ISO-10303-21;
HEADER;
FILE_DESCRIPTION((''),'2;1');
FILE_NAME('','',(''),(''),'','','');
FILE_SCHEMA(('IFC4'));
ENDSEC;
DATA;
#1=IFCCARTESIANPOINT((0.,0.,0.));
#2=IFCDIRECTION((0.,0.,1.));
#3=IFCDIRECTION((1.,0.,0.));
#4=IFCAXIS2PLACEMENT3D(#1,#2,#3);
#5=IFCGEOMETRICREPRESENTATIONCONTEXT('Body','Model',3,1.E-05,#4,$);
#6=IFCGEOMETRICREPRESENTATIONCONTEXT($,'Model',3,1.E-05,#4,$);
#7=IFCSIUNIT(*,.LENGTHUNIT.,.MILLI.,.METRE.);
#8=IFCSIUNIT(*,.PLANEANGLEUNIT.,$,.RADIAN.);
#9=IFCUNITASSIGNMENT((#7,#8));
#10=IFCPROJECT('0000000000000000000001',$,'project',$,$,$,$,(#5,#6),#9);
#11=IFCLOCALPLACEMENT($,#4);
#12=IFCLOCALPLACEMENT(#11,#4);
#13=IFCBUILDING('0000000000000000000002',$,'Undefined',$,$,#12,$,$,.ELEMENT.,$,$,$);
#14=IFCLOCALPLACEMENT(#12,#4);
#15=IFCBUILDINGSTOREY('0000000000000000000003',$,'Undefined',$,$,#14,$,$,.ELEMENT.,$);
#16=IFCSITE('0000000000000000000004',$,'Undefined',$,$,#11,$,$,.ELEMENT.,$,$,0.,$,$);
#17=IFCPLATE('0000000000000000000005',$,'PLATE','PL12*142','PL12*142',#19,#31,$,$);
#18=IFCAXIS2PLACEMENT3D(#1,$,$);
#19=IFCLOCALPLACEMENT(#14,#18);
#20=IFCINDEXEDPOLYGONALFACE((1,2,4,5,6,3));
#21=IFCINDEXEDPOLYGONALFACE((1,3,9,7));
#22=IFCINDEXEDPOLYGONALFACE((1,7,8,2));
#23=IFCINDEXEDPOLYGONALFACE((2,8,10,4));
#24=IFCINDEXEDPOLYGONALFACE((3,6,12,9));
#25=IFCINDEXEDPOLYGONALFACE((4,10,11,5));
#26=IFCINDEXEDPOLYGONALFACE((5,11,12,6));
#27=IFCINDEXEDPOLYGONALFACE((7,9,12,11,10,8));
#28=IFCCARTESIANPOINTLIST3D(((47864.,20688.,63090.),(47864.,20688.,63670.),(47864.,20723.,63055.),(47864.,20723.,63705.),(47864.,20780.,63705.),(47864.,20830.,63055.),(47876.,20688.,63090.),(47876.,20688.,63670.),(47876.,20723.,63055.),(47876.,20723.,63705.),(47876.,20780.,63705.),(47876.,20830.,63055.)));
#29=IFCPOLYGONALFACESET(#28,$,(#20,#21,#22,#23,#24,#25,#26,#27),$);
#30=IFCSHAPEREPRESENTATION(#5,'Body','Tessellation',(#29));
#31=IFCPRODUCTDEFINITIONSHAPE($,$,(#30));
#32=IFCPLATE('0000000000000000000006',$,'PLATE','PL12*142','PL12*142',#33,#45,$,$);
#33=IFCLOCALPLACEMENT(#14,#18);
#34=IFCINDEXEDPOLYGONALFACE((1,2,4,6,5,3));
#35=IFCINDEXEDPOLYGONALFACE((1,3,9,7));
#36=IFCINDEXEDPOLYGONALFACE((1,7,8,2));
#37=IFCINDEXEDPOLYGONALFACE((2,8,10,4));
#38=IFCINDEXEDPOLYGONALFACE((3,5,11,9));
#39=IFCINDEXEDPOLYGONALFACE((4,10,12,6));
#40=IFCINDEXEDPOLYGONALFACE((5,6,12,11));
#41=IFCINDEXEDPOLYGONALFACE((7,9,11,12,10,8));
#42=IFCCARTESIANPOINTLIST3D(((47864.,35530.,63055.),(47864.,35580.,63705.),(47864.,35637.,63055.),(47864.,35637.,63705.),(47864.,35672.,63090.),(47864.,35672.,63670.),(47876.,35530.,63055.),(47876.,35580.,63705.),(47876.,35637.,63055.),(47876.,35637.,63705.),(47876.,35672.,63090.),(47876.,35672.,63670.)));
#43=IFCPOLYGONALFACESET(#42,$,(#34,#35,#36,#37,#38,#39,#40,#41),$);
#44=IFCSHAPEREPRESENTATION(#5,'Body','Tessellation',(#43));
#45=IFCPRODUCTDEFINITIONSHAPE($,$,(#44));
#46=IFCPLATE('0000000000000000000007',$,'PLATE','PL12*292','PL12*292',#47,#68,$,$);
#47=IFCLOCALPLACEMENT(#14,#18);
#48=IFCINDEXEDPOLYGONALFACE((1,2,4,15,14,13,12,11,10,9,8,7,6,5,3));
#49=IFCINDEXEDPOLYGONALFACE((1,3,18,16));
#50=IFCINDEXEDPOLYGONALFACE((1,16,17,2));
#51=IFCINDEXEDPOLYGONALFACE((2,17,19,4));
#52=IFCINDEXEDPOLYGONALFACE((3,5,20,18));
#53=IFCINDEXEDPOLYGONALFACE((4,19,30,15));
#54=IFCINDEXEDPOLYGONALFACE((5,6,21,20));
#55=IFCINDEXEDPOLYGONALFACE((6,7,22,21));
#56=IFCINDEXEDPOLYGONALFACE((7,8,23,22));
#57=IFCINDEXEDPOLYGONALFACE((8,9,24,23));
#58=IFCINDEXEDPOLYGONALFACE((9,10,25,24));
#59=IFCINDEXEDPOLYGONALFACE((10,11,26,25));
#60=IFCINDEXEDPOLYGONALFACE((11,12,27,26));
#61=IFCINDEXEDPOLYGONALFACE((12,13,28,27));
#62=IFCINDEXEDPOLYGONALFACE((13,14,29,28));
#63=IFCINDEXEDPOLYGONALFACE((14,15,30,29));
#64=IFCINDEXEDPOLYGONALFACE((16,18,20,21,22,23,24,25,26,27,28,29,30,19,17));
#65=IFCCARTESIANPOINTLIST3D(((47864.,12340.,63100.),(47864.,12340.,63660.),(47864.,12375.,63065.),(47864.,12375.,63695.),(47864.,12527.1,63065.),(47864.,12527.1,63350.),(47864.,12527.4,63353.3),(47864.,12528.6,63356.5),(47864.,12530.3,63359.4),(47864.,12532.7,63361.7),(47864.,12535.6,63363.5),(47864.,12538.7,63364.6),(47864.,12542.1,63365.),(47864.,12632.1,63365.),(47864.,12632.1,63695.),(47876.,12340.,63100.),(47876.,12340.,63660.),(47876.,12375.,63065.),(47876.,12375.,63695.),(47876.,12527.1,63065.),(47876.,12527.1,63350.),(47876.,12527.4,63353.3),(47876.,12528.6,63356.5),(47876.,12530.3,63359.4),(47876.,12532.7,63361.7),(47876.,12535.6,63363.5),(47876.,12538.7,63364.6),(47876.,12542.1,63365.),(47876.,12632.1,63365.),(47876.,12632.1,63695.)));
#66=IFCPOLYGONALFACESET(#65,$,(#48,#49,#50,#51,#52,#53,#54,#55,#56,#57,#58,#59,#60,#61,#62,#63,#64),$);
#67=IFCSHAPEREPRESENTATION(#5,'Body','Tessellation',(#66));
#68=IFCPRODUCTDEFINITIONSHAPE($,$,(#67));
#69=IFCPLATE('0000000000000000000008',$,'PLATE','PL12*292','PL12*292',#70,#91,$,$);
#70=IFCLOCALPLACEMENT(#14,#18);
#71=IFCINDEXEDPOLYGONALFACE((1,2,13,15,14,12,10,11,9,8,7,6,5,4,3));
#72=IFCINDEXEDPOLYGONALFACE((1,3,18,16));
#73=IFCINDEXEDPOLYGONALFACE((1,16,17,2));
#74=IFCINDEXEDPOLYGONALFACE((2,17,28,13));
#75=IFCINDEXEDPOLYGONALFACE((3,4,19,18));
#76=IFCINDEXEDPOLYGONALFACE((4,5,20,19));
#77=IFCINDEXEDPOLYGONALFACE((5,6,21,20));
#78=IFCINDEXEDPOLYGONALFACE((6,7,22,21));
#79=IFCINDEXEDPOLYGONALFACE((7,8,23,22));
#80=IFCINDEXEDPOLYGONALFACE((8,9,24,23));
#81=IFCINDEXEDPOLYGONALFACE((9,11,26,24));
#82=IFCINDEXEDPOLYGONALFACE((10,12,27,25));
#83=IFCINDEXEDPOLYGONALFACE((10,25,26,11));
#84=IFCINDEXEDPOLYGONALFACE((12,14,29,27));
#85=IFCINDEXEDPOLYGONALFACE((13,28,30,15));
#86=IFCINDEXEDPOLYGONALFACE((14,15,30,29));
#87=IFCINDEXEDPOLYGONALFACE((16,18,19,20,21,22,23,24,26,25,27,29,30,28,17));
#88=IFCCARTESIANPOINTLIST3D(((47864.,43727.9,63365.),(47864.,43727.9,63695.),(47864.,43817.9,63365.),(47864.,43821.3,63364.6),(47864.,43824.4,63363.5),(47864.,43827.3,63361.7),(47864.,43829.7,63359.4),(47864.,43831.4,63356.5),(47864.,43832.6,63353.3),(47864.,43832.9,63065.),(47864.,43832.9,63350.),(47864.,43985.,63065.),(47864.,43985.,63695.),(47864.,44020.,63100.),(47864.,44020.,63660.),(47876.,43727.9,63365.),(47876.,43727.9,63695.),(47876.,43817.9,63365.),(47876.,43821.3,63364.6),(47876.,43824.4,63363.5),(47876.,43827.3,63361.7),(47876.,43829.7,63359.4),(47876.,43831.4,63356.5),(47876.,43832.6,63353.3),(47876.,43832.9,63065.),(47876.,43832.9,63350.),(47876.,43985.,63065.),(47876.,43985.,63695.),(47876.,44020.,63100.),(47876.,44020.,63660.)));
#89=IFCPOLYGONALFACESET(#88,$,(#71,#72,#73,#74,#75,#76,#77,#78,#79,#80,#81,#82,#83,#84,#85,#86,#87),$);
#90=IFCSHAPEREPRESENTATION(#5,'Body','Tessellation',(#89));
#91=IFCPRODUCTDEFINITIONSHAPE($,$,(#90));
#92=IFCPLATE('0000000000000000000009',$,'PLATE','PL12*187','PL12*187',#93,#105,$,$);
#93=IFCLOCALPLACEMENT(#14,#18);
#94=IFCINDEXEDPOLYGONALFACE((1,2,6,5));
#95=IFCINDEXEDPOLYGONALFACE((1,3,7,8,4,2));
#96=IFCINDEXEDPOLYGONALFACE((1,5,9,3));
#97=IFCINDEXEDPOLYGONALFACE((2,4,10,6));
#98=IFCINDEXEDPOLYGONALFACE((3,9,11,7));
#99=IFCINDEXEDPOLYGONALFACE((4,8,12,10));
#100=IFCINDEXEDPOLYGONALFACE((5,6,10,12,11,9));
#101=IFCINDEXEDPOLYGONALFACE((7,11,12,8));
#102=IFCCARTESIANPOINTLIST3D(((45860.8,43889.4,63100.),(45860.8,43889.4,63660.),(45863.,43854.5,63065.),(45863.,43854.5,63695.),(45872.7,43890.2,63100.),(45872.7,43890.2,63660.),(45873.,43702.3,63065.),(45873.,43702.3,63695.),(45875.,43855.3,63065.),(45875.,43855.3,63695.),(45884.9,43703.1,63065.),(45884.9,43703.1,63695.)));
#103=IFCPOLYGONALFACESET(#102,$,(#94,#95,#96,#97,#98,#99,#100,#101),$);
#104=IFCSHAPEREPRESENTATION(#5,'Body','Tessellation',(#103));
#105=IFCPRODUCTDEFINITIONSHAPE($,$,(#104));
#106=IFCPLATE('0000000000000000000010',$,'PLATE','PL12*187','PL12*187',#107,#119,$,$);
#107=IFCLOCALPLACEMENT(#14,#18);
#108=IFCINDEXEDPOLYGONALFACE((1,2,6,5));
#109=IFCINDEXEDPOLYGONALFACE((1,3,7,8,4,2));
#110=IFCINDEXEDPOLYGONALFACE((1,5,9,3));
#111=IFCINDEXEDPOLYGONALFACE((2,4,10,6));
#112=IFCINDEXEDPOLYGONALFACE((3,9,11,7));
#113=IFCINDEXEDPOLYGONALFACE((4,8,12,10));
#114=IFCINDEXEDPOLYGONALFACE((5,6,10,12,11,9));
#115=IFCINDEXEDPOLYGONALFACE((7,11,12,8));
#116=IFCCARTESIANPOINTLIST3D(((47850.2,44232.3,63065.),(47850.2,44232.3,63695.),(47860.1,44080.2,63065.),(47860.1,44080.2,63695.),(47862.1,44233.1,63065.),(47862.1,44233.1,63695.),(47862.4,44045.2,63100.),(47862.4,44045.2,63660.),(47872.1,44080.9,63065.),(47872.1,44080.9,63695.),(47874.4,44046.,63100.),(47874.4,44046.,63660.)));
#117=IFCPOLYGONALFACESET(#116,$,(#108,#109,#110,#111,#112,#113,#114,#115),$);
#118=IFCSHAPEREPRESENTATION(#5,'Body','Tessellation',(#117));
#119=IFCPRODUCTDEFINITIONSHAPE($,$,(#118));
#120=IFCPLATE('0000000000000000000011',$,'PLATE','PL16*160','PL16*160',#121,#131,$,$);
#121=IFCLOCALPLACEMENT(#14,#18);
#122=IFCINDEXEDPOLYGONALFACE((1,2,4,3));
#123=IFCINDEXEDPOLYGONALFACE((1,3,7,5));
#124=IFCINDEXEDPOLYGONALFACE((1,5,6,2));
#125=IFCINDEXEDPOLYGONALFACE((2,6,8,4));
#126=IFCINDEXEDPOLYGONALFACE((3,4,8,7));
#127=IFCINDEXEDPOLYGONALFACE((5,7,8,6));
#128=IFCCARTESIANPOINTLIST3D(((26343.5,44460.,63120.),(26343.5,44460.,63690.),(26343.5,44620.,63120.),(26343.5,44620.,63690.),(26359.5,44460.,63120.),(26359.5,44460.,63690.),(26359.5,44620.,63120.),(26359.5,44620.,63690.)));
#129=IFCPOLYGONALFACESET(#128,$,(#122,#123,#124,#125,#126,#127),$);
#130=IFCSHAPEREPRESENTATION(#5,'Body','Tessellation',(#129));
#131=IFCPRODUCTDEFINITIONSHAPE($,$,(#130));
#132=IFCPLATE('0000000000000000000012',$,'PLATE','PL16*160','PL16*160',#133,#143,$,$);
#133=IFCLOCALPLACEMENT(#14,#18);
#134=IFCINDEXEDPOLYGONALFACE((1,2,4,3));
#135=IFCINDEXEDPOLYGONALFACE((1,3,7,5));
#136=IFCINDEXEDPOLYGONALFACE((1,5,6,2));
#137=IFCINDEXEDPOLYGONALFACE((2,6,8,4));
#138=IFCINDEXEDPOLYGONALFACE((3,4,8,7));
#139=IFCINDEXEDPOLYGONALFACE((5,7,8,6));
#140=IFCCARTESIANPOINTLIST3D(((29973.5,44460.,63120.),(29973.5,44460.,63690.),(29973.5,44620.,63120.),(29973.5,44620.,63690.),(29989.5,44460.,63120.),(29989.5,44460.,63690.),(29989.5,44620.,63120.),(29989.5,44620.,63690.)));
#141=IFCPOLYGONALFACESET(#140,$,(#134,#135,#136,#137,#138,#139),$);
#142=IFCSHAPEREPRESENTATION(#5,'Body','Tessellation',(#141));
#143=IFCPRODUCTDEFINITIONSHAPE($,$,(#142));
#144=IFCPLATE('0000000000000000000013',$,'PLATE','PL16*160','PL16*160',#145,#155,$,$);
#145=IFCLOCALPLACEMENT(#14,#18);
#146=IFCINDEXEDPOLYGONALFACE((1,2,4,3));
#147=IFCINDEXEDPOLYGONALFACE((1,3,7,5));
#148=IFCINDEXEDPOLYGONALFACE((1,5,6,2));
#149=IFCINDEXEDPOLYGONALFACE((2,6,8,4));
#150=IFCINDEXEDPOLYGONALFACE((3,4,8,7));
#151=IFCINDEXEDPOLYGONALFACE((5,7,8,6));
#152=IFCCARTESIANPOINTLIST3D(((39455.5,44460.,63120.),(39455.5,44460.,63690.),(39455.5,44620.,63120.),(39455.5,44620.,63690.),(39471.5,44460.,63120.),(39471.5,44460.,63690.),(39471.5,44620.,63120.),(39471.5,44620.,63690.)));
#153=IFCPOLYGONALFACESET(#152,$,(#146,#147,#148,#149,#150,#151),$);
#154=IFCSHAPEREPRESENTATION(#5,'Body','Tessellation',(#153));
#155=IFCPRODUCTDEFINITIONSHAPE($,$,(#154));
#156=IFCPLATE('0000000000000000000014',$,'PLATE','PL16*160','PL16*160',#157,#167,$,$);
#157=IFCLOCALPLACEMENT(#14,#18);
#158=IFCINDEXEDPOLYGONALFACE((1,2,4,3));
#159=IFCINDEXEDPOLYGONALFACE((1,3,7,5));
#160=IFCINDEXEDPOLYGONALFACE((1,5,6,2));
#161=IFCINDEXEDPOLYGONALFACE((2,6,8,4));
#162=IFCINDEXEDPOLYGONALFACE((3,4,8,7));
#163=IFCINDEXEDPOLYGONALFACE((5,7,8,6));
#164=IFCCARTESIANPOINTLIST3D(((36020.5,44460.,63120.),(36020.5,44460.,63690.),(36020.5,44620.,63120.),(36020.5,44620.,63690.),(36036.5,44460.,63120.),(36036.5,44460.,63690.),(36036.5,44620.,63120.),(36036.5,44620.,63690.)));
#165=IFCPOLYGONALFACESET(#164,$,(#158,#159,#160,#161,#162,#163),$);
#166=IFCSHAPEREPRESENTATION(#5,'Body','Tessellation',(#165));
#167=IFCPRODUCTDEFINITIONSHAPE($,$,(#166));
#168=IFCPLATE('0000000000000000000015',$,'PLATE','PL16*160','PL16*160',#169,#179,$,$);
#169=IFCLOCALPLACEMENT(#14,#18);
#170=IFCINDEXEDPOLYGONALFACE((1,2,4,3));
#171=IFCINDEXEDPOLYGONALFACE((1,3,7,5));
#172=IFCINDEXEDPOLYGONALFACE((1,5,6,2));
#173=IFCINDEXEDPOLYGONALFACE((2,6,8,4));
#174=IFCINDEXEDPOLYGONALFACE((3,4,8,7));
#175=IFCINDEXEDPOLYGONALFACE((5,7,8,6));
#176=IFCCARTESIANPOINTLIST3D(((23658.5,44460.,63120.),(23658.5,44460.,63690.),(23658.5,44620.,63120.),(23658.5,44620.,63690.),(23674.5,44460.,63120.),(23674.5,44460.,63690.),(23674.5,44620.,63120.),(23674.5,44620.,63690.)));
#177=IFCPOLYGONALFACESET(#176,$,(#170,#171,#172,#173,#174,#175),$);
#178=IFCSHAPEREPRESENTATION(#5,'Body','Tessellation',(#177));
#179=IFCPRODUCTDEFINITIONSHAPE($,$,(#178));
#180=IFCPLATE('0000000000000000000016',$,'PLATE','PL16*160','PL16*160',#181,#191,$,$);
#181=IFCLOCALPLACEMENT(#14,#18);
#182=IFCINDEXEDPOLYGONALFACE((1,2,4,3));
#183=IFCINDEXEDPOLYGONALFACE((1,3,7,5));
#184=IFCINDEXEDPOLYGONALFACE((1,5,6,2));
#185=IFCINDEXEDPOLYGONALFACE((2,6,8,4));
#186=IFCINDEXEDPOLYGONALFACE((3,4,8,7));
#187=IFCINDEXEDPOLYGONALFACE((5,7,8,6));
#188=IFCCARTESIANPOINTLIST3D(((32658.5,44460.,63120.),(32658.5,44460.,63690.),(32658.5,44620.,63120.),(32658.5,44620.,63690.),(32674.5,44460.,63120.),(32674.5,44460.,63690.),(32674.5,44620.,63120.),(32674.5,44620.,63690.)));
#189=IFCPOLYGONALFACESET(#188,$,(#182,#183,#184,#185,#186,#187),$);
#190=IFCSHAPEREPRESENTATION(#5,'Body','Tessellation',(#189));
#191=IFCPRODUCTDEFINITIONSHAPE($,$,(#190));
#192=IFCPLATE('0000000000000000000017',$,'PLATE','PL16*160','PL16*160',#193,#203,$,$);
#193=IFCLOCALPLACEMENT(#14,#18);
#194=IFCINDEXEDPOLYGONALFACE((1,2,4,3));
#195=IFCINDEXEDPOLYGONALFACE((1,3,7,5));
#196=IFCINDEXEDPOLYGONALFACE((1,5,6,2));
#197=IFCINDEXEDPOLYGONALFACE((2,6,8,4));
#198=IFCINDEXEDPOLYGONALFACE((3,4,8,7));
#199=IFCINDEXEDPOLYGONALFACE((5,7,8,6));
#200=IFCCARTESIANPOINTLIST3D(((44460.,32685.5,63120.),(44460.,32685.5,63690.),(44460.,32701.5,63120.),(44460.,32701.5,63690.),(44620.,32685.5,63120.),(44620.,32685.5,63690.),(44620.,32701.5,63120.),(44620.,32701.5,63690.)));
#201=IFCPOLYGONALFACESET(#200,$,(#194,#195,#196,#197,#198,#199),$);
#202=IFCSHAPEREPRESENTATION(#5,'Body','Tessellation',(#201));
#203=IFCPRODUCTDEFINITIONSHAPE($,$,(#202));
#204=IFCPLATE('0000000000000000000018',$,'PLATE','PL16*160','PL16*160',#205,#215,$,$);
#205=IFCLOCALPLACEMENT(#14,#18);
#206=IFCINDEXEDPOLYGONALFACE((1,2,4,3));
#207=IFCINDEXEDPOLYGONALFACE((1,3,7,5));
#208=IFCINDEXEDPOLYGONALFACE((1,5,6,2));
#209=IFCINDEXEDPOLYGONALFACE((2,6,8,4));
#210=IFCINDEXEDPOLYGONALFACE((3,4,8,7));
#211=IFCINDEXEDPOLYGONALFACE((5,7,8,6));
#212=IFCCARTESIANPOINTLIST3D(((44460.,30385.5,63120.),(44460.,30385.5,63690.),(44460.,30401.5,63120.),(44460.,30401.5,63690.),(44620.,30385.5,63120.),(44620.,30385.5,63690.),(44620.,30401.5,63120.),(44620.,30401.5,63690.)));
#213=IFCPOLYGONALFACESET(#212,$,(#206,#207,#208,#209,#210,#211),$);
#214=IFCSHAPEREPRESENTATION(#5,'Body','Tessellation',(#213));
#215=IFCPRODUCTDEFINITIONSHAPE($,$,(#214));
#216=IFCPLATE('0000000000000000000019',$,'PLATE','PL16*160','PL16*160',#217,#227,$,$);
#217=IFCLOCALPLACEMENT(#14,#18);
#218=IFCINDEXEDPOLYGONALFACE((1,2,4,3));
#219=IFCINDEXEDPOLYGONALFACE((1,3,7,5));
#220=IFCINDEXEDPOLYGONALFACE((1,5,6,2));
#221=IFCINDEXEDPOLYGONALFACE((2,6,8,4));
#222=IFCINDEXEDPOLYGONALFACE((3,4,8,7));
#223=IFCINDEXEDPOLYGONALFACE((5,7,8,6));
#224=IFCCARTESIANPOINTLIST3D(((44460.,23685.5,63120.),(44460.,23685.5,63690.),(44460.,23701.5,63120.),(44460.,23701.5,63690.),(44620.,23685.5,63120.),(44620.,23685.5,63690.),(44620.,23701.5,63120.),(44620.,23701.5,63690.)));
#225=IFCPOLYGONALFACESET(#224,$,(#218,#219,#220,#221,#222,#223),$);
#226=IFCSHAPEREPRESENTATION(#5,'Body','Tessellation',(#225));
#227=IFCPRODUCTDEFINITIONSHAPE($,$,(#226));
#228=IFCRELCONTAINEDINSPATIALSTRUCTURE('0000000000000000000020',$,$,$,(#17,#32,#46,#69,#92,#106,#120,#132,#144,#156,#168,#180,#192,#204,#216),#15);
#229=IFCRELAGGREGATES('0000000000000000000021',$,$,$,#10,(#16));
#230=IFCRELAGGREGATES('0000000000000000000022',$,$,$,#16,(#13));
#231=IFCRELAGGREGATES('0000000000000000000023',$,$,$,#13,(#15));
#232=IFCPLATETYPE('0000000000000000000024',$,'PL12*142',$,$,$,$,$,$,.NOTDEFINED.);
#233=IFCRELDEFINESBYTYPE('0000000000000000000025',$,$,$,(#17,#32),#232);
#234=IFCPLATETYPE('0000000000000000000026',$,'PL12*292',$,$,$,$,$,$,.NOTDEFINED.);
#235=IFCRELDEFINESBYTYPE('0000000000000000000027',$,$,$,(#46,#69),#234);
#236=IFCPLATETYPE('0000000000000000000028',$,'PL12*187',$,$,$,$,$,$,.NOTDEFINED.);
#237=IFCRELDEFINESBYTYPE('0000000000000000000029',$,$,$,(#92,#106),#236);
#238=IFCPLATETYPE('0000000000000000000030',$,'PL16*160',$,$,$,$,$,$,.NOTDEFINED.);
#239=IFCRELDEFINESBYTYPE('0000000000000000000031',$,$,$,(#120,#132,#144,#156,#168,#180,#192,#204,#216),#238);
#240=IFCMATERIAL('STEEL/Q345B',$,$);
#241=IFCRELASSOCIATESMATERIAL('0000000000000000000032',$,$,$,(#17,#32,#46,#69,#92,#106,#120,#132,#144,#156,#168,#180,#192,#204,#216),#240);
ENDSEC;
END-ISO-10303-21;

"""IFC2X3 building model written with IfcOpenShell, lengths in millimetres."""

from ifc_helpers import new_model, si_unit, frame, origin_with_axes, place, context, project, spatial, polyline, outline, extrude, material, type_object, element, save


model = new_model("IFC2X3")

# Units and contexts
model_context_1 = context("Model", 3, precision=1e-05, world=origin_with_axes(), identifier="Body")
model_context_2 = context("Model", 3, precision=1e-05, world=origin_with_axes())
ifc_project = project(units=[si_unit("LENGTHUNIT", "METRE", prefix="MILLI"), si_unit("PLANEANGLEUNIT", "RADIAN")], contexts=[model_context_1, model_context_2])

# Site, building, storey
site_placement = place(None, origin_with_axes())
site = spatial("IfcSite", under=ifc_project, at=site_placement, Name="Undefined", CompositionType="ELEMENT", RefElevation=0.0)
building_placement = place(site_placement, origin_with_axes())
building = spatial("IfcBuilding", under=site, at=building_placement, Name="Undefined", CompositionType="ELEMENT")
storey_placement = place(building_placement, origin_with_axes())
storey = spatial("IfcBuildingStorey", under=building, at=storey_placement, Name="Undefined", CompositionType="ELEMENT")

# Shared definitions
ifc_material_1 = material(Name="STEEL/Q345B")

# Plates
plate_type_1 = type_object("IfcPlateType", Name="PL12*142", PredefinedType="NOTDEFINED")
for number, where, z_axis, x_axis, name in (
    (1, (47870.0, 20830.0, 63055.0), (-1.0, 0.0, 0.0), (0.0, -1.0, 0.0), "PLATE"),
    (2, (47870.0, 35530.0, 63055.0), (1.0, 0.0, 0.0), (0.0, 1.0, 0.0), "PLATE"),
):
    element("IfcPlate", number, at=place(storey_placement, frame(where, z_axis=z_axis, x_axis=x_axis)), inside=storey, type_object=plate_type_1, material=ifc_material_1, Name=name, Description="PL12*142", ObjectType="PL12*142", context=model_context_1, shape_type="SweptSolid", body=[
        extrude(outline(polyline([(0.0, 0.0), (107.0, 0.0), (142.0, 35.0), (142.0, 615.0), (107.0, 650.0), (50.0, 650.0), (0.0, 0.0)])), frame((0.0, 0.0, -6.0), z_axis=(0.0, 0.0, 1.0), x_axis=(1.0, 0.0, 0.0)), (0.0, 0.0, 1.0), 12.0),
    ])
plate_type_2 = type_object("IfcPlateType", Name="PL12*292", PredefinedType="NOTDEFINED")
for number, where, z_axis, x_axis, name in (
    (3, (47870.0, 12632.1, 63695.0), (1.0, 0.0, 0.0), (0.0, -1.0, 0.0), "PLATE"),
    (4, (47870.0, 43727.9, 63695.0), (-1.0, 0.0, 0.0), (0.0, 1.0, 0.0), "PLATE"),
):
    element("IfcPlate", number, at=place(storey_placement, frame(where, z_axis=z_axis, x_axis=x_axis)), inside=storey, type_object=plate_type_2, material=ifc_material_1, Name=name, Description="PL12*292", ObjectType="PL12*292", context=model_context_1, shape_type="SweptSolid", body=[
        extrude(outline(polyline([(0.0, 0.0), (257.2, 0.0), (292.2, 35.0), (292.2, 595.0), (257.2, 630.0), (105.1, 630.0), (105.1, 345.0), (104.7, 341.7), (103.6, 338.5), (101.8, 335.6), (99.4, 333.3), (96.6, 331.5), (93.4, 330.4), (90.1, 330.0), (0.0, 330.0), (0.0, 0.0)])), frame((0.0, 0.0, -6.0), z_axis=(0.0, 0.0, 1.0), x_axis=(1.0, 0.0, 0.0)), (0.0, 0.0, 1.0), 12.0),
    ])
plate_type_3 = type_object("IfcPlateType", Name="PL12*187", PredefinedType="NOTDEFINED")
for number, where, z_axis, x_axis, name in (
    (5, (45866.7, 43889.8, 63065.0), (-0.997873, -0.065183, 0.0), (0.065183, -0.997873, 0.0), "PLATE"),
    (6, (47868.4, 44045.6, 63065.0), (0.997873, 0.065184, 0.0), (-0.065184, 0.997873, 0.0), "PLATE"),
):
    element("IfcPlate", number, at=place(storey_placement, frame(where, z_axis=z_axis, x_axis=x_axis)), inside=storey, type_object=plate_type_3, material=ifc_material_1, Name=name, Description="PL12*187", ObjectType="PL12*187", context=model_context_1, shape_type="SweptSolid", body=[
        extrude(outline(polyline([(0.0, 35.0), (35.0, 0.0), (187.5, 0.0), (187.5, 630.0), (35.0, 630.0), (0.0, 595.0), (0.0, 35.0)])), frame((0.0, 0.0, -6.0), z_axis=(0.0, 0.0, 1.0), x_axis=(1.0, 0.0, 0.0)), (0.0, 0.0, 1.0), 12.0),
    ])
plate_type_4 = type_object("IfcPlateType", Name="PL16*160", PredefinedType="NOTDEFINED")
for number, where, z_axis, x_axis, name in (
    (7, (26351.5, 44620.0, 63690.0), (1.0, 0.0, 0.0), (0.0, -1.0, 0.0), "PLATE"),
    (8, (29981.5, 44620.0, 63690.0), (1.0, 0.0, 0.0), (0.0, -1.0, 0.0), "PLATE"),
    (9, (39463.5, 44620.0, 63690.0), (1.0, 0.0, 0.0), (0.0, -1.0, 0.0), "PLATE"),
    (10, (36028.5, 44620.0, 63690.0), (1.0, 0.0, 0.0), (0.0, -1.0, 0.0), "PLATE"),
    (11, (23666.5, 44620.0, 63690.0), (1.0, 0.0, 0.0), (0.0, -1.0, 0.0), "PLATE"),
    (12, (32666.5, 44620.0, 63690.0), (1.0, 0.0, 0.0), (0.0, -1.0, 0.0), "PLATE"),
    (13, (44620.0, 32693.5, 63690.0), (0.0, -1.0, 0.0), (-1.0, 0.0, 0.0), "PLATE"),
    (14, (44620.0, 30393.5, 63690.0), (0.0, -1.0, 0.0), (-1.0, 0.0, 0.0), "PLATE"),
    (15, (44620.0, 23693.5, 63690.0), (0.0, -1.0, 0.0), (-1.0, 0.0, 0.0), "PLATE"),
):
    element("IfcPlate", number, at=place(storey_placement, frame(where, z_axis=z_axis, x_axis=x_axis)), inside=storey, type_object=plate_type_4, material=ifc_material_1, Name=name, Description="PL16*160", ObjectType="PL16*160", context=model_context_1, shape_type="SweptSolid", body=[
        extrude(outline(polyline([(0.0, 0.0), (160.0, 0.0), (160.0, 570.0), (0.0, 570.0), (0.0, 0.0)])), frame((0.0, 0.0, -8.0), z_axis=(0.0, 0.0, 1.0), x_axis=(1.0, 0.0, 0.0)), (0.0, 0.0, 1.0), 16.0),
    ])

save(model, "model.ifc")
